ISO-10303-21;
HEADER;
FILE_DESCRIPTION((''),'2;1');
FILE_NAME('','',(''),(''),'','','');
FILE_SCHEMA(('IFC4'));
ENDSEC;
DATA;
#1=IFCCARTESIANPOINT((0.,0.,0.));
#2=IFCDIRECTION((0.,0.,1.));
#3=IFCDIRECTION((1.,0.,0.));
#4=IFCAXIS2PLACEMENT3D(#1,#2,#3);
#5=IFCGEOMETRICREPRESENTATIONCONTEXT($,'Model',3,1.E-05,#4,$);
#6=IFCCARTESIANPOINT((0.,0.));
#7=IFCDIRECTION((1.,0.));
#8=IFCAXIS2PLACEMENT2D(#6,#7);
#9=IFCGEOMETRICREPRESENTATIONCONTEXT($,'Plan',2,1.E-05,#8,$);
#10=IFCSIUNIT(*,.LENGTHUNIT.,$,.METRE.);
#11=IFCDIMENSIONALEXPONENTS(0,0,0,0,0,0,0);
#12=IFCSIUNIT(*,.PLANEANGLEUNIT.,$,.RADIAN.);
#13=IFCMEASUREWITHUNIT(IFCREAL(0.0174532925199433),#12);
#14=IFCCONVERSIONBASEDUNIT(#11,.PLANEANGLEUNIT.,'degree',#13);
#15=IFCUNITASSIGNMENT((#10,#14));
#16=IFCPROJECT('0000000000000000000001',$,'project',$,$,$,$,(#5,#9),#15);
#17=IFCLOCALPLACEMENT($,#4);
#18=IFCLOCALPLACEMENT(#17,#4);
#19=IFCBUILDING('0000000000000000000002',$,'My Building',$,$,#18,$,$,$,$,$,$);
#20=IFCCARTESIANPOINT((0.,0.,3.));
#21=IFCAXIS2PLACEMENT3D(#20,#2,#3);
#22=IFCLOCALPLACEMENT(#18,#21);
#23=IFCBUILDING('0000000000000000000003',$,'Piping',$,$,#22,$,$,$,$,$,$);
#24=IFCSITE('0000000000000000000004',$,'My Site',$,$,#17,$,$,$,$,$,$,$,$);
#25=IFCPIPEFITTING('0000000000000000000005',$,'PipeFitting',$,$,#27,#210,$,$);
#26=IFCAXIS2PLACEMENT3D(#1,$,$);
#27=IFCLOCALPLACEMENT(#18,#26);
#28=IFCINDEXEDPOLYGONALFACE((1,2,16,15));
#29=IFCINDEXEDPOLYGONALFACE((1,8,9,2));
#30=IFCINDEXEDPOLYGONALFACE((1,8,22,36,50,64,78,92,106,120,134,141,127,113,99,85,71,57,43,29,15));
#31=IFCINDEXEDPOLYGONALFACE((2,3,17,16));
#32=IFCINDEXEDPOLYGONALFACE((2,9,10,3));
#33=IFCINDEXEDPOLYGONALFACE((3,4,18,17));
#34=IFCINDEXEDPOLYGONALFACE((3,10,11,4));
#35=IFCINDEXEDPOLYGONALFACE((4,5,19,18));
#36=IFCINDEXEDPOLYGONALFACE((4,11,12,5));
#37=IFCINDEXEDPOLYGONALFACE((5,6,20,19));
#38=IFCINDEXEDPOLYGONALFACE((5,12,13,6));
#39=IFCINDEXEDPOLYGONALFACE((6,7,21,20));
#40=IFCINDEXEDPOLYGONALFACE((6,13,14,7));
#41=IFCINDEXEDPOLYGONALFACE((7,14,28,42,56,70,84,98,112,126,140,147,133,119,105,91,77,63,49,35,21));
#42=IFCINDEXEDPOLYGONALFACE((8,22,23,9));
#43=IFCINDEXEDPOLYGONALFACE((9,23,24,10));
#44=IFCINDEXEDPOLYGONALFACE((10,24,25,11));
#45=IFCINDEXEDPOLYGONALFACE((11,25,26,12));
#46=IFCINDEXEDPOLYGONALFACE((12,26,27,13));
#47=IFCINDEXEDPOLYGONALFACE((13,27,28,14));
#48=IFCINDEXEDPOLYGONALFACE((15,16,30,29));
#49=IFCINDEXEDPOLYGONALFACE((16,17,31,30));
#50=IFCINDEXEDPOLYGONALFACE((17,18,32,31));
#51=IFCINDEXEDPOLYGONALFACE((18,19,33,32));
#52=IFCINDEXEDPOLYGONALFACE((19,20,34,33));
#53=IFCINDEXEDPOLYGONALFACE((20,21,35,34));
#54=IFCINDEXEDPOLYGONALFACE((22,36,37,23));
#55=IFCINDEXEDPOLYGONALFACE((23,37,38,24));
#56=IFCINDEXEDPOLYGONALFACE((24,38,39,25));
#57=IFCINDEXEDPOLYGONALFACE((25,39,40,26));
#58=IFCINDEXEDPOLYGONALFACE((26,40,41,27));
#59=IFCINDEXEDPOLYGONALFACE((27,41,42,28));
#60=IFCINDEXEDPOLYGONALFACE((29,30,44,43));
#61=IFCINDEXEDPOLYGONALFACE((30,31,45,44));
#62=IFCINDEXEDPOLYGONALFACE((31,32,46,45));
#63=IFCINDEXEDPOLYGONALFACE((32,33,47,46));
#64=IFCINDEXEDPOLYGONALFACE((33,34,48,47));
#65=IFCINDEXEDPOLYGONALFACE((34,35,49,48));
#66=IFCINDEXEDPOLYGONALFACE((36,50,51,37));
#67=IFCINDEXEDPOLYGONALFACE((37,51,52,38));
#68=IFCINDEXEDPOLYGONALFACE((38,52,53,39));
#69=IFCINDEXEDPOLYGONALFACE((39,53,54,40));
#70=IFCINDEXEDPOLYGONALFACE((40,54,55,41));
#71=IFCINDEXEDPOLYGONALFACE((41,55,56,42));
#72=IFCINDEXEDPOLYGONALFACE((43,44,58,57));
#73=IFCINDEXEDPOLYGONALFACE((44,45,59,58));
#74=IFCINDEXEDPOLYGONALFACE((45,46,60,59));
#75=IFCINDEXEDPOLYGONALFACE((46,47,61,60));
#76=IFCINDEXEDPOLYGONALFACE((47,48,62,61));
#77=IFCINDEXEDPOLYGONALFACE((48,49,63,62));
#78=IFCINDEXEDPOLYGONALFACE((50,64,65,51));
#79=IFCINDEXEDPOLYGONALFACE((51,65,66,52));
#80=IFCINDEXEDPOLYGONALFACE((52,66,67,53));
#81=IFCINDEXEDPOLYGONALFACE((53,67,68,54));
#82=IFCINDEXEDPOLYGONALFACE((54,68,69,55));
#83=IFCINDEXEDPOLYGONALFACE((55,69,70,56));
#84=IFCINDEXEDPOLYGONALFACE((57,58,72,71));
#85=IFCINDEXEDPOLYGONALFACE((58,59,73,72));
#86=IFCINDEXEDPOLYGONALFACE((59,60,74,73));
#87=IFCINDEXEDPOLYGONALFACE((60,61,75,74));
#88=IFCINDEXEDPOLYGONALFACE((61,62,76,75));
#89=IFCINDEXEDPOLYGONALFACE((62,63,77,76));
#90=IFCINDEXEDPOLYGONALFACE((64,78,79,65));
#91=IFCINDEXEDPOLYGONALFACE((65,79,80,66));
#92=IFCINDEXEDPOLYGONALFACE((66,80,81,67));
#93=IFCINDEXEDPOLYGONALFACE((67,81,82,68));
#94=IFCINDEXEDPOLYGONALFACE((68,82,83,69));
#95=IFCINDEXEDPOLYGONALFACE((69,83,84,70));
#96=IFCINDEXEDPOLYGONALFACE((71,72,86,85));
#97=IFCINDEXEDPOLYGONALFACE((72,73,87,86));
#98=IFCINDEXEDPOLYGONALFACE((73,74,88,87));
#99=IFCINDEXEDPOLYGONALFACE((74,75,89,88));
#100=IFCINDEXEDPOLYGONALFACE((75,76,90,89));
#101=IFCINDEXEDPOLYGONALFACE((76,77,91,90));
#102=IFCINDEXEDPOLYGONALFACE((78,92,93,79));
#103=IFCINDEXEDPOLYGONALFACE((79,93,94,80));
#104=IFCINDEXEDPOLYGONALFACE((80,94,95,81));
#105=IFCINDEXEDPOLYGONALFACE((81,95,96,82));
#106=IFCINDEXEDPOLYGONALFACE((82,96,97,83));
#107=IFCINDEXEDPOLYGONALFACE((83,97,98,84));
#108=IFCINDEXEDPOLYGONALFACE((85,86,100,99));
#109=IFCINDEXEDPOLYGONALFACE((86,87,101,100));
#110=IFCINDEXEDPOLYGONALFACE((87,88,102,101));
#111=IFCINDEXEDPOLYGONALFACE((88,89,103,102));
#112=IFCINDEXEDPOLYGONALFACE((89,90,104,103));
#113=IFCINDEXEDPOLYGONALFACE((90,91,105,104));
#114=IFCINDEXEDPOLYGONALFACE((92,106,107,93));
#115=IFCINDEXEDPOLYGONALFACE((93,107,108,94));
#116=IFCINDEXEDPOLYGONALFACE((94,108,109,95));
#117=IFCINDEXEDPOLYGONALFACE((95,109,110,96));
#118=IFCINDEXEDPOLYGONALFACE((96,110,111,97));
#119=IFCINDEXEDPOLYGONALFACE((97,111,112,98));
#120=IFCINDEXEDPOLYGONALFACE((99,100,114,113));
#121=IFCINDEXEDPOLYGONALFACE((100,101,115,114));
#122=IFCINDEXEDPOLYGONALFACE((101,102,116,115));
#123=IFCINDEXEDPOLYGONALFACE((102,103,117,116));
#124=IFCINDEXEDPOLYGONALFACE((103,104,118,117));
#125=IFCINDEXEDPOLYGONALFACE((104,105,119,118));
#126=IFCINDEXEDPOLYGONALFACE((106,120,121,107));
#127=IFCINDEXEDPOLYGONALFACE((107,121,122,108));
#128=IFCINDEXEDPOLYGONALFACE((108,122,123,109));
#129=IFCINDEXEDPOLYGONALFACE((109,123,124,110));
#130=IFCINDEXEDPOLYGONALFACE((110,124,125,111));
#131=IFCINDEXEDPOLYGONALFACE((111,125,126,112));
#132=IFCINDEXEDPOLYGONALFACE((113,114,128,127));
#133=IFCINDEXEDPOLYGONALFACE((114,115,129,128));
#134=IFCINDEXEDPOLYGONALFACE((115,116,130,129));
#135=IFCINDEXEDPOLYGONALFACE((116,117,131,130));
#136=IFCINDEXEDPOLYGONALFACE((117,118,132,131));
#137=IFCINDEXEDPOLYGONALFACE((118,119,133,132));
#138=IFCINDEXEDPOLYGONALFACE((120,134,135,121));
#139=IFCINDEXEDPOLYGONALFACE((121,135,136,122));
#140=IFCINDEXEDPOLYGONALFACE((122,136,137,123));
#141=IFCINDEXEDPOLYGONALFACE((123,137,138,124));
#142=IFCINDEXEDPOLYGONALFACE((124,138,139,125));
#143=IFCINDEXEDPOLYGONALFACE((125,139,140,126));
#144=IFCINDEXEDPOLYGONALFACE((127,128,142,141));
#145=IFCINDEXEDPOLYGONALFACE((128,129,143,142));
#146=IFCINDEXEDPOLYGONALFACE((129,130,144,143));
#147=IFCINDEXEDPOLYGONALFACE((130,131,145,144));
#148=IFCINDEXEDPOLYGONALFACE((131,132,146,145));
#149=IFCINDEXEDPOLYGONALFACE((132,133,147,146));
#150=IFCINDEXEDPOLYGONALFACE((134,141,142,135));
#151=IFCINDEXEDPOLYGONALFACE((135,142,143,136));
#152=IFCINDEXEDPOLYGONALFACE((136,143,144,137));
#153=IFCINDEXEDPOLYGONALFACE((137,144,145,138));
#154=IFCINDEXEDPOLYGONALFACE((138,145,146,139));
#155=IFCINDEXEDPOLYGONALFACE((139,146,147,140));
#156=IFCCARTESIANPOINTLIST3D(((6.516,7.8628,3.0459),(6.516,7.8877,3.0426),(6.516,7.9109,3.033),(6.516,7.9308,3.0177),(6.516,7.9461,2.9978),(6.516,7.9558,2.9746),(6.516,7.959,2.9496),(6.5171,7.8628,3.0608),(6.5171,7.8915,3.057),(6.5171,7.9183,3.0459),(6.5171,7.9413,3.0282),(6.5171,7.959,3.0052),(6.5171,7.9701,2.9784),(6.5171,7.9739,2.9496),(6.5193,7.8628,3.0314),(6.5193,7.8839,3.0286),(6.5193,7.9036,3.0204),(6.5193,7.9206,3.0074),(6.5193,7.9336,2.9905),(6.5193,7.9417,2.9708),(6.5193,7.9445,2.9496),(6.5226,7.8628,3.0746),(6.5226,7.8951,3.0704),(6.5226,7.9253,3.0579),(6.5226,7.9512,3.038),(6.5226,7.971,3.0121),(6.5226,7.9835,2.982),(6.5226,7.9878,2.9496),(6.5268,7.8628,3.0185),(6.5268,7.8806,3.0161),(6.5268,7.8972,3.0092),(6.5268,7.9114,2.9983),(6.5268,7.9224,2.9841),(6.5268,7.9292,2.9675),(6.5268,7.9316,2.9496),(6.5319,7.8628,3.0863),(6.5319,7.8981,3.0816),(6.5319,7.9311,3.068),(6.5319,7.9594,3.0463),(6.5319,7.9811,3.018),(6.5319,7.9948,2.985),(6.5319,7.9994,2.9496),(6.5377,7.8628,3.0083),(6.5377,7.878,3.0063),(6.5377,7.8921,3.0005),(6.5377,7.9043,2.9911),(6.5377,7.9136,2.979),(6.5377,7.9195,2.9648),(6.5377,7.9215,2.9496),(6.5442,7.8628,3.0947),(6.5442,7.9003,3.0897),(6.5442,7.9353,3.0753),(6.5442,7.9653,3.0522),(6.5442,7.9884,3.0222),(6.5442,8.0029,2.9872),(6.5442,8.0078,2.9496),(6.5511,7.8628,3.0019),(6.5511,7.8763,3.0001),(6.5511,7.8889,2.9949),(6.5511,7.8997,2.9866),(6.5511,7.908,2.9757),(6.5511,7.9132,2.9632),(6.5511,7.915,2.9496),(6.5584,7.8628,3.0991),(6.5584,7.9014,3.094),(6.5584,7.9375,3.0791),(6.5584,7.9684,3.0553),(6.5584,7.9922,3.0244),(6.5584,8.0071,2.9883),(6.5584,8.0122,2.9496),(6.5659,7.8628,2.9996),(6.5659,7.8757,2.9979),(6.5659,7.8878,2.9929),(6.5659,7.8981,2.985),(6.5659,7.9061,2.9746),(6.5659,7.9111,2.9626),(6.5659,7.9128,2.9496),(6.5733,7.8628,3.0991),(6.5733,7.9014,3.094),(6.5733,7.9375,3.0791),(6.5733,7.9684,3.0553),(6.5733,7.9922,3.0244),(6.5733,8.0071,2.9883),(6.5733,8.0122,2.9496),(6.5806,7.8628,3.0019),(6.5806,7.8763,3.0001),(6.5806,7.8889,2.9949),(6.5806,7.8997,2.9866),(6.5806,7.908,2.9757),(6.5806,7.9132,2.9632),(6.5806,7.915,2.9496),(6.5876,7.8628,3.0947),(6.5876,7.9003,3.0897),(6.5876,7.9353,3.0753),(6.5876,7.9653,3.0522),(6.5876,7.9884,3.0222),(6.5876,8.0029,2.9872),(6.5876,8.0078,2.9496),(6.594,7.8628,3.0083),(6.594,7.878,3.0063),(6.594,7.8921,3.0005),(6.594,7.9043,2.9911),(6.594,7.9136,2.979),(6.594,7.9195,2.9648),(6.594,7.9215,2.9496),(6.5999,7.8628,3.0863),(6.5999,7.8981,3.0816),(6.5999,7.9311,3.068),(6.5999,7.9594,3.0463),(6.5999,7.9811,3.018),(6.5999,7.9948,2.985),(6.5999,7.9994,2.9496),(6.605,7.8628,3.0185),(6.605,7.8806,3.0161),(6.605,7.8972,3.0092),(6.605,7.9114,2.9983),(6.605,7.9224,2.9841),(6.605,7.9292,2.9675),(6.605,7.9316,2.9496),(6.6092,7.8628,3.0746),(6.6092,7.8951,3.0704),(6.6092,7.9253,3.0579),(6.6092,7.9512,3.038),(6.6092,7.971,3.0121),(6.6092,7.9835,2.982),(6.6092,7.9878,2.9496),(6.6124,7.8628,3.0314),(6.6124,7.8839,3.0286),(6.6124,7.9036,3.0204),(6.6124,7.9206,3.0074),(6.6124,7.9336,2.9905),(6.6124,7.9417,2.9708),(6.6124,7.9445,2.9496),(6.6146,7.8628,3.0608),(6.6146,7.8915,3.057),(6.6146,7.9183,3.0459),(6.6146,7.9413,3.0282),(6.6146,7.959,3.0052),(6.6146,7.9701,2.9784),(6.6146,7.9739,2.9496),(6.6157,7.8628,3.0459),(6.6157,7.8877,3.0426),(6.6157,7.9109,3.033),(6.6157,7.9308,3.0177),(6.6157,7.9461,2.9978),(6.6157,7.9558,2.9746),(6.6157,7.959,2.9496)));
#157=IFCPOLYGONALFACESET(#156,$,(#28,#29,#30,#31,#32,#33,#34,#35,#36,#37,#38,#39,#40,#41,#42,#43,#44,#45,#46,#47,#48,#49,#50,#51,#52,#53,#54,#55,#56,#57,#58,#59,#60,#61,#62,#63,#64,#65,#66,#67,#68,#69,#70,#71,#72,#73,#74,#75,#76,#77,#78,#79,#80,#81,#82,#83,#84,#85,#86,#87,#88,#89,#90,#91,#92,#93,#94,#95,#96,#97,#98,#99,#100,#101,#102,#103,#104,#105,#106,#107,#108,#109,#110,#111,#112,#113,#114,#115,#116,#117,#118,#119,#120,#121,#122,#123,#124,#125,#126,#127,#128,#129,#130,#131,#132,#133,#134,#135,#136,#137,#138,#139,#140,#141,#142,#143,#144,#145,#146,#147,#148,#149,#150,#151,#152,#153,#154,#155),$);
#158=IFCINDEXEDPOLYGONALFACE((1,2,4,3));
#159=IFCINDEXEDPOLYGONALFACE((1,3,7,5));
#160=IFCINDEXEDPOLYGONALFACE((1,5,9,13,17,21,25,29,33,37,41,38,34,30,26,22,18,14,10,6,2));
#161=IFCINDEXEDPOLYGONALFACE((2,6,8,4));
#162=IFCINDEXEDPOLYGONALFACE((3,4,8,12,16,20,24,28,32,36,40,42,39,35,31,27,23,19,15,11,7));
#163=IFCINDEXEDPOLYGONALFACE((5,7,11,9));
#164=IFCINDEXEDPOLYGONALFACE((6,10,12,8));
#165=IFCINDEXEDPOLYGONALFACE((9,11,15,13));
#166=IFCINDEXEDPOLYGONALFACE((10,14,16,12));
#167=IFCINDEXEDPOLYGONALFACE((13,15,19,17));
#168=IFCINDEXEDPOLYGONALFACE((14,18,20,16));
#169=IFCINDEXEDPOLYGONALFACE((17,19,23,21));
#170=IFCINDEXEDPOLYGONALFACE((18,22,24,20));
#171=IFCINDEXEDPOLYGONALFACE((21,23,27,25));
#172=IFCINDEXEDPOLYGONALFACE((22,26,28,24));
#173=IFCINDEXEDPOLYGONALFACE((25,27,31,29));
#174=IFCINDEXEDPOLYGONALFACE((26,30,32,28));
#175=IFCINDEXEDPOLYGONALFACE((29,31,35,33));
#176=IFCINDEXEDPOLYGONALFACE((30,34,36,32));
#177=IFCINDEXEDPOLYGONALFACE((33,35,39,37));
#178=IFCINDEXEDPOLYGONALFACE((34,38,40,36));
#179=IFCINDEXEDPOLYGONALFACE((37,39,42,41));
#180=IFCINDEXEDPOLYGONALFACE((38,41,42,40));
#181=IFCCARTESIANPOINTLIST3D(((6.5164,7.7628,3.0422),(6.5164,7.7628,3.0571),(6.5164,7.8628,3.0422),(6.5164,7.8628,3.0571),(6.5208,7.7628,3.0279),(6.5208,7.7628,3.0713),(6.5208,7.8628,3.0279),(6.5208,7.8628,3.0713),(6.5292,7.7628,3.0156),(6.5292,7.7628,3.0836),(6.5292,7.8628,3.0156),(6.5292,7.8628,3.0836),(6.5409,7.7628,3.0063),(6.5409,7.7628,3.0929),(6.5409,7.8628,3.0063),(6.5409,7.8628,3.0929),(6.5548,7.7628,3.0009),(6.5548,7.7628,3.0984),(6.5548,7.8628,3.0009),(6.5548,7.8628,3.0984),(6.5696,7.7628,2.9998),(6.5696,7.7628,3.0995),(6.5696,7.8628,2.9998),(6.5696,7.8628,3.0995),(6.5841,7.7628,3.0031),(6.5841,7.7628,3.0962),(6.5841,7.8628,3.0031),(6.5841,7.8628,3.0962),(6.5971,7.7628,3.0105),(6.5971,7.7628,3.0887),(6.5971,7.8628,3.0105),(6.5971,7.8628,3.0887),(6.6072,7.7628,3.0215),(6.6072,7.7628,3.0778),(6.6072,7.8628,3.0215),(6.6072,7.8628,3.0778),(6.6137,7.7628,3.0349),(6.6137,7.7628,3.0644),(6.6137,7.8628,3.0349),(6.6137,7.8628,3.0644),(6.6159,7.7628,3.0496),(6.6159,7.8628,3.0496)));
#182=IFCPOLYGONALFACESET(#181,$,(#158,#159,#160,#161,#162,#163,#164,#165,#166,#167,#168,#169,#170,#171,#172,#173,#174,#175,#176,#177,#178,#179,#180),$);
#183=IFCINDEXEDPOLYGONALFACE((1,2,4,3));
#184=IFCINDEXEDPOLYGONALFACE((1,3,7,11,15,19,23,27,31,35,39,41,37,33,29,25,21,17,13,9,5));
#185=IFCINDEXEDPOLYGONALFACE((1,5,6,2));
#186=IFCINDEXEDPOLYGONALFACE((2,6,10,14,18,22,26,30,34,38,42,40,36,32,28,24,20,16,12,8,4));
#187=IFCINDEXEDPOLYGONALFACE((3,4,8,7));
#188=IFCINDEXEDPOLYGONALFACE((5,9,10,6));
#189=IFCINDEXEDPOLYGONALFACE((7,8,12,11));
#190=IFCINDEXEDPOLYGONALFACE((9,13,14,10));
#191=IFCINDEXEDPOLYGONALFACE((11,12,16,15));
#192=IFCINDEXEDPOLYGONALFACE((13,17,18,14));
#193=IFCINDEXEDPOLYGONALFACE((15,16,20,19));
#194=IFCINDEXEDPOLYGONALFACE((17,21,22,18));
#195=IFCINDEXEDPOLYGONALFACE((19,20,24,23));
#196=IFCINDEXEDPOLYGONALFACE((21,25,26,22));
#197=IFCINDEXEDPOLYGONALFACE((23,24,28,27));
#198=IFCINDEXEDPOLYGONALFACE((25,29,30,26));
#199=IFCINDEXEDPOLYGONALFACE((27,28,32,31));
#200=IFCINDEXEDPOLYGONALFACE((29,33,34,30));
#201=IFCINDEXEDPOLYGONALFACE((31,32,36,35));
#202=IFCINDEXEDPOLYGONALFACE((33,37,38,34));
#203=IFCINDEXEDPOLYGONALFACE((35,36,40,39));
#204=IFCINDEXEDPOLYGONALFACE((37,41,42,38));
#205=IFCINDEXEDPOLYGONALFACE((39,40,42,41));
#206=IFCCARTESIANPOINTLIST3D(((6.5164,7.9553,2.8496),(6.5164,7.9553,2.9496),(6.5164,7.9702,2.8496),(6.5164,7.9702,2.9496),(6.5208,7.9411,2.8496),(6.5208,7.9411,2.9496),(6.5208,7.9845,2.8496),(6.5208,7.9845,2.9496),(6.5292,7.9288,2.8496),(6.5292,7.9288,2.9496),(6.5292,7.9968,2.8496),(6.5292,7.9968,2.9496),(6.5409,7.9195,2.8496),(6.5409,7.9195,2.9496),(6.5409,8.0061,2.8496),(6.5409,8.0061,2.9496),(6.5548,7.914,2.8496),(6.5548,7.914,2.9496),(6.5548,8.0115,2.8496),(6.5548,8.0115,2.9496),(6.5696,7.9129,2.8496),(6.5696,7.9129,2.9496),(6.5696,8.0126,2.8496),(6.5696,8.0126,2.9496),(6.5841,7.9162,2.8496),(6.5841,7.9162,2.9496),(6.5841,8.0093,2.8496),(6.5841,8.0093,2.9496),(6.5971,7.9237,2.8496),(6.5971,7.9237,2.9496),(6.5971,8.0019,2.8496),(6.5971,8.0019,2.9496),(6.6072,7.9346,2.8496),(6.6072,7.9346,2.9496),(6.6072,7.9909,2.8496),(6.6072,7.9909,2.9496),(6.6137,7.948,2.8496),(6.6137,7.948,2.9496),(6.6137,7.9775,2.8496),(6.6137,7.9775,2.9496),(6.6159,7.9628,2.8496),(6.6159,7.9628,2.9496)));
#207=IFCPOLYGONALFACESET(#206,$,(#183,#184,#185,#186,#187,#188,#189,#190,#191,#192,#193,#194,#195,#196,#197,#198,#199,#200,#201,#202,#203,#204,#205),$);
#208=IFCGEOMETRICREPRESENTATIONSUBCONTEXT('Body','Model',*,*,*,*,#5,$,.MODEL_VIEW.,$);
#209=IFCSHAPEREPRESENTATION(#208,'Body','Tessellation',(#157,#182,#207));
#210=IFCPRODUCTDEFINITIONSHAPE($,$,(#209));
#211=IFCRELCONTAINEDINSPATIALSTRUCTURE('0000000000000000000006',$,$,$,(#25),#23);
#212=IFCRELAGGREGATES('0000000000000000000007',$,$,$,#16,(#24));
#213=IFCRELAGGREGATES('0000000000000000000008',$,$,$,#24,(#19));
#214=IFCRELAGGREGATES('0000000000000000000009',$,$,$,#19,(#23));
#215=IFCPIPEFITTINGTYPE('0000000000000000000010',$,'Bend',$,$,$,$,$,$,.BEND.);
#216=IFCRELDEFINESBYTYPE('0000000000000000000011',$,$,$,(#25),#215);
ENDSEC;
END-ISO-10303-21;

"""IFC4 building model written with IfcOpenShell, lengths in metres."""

from ifc_helpers import new_model, entity, si_unit, converted_unit, frame, origin_with_axes, origin_2d_with_axis, place, context, subcontext, project, spatial, circle, extrude, source, transform, mapped, type_object, type_shapes, element, save


model = new_model("IFC4")

# Units and contexts
model_context = context("Model", 3, precision=1e-05, world=origin_with_axes())
plan_context = context("Plan", 2, precision=1e-05, world=origin_2d_with_axis())
body_context = subcontext(model_context, "Body", "Model", "MODEL_VIEW")
ifc_project = project(units=[si_unit("LENGTHUNIT", "METRE"), converted_unit("PLANEANGLEUNIT", "degree", entity("IfcReal", 0.0174532925199433), si_unit("PLANEANGLEUNIT", "RADIAN"), dimensions=[0, 0, 0, 0, 0, 0, 0])], contexts=[model_context, plan_context])

# Site, buildings
site_placement = place(None, origin_with_axes())
site = spatial("IfcSite", under=ifc_project, at=site_placement, Name="My Site")
building_1_placement = place(site_placement, origin_with_axes())
building_1 = spatial("IfcBuilding", under=site, at=building_1_placement, Name="My Building")
building_2_placement = place(building_1_placement, frame((0.0, 0.0, 3.0), z_axis=(0.0, 0.0, 1.0), x_axis=(1.0, 0.0, 0.0)))
building_2 = spatial("IfcBuilding", under=building_1, at=building_2_placement, Name="Piping")

# Pipe fitting
pipe_fitting_type_1 = type_object("IfcPipeFittingType", Name="Bend", PredefinedType="BEND")
shared_shape = source(origin_with_axes(), body_context, "Body", "SolidModel", [
    entity("IfcSweptDiskSolid", entity("IfcIndexedPolyCurve", entity("IfcCartesianPointList3D", [[0.0, 0.0, 0.1], [0.0, 0.0293, 0.1707], [0.0, 0.1, 0.2]]), [entity("IfcArcIndex", [1, 2, 3])]), 0.05),
    extrude(circle(Radius=0.05), origin_with_axes(), (0.0, 0.0, 1.0), 0.1),
    extrude(circle(Radius=0.05), frame((0.0, 0.1, 0.2), z_axis=(0.0, 1.0, 0.0), x_axis=(1.0, 0.0, 0.0)), (0.0, 0.0, 1.0), 0.1),
])
type_shapes(pipe_fitting_type_1, [shared_shape])
for number, where, z_axis, x_axis, name in (
    (1, (6.5659, 7.7628, 0.0496), (0.0, 1.0, 0.0), (1.0, 0.0, 0.0), "PipeFitting"),
):
    element("IfcPipeFitting", number, at=place(building_2_placement, frame(where, z_axis=z_axis, x_axis=x_axis)), inside=building_2, type_object=pipe_fitting_type_1, Name=name, context=body_context, shape_type="MappedRepresentation", body=[
        mapped(shared_shape, transform((0.0, 0.0, 0.0), x_axis=(1.0, 0.0, 0.0), y_axis=(0.0, 1.0, 0.0), z_axis=(0.0, 0.0, 1.0), scale=1.0)),
    ])

save(model, "model.ifc")
